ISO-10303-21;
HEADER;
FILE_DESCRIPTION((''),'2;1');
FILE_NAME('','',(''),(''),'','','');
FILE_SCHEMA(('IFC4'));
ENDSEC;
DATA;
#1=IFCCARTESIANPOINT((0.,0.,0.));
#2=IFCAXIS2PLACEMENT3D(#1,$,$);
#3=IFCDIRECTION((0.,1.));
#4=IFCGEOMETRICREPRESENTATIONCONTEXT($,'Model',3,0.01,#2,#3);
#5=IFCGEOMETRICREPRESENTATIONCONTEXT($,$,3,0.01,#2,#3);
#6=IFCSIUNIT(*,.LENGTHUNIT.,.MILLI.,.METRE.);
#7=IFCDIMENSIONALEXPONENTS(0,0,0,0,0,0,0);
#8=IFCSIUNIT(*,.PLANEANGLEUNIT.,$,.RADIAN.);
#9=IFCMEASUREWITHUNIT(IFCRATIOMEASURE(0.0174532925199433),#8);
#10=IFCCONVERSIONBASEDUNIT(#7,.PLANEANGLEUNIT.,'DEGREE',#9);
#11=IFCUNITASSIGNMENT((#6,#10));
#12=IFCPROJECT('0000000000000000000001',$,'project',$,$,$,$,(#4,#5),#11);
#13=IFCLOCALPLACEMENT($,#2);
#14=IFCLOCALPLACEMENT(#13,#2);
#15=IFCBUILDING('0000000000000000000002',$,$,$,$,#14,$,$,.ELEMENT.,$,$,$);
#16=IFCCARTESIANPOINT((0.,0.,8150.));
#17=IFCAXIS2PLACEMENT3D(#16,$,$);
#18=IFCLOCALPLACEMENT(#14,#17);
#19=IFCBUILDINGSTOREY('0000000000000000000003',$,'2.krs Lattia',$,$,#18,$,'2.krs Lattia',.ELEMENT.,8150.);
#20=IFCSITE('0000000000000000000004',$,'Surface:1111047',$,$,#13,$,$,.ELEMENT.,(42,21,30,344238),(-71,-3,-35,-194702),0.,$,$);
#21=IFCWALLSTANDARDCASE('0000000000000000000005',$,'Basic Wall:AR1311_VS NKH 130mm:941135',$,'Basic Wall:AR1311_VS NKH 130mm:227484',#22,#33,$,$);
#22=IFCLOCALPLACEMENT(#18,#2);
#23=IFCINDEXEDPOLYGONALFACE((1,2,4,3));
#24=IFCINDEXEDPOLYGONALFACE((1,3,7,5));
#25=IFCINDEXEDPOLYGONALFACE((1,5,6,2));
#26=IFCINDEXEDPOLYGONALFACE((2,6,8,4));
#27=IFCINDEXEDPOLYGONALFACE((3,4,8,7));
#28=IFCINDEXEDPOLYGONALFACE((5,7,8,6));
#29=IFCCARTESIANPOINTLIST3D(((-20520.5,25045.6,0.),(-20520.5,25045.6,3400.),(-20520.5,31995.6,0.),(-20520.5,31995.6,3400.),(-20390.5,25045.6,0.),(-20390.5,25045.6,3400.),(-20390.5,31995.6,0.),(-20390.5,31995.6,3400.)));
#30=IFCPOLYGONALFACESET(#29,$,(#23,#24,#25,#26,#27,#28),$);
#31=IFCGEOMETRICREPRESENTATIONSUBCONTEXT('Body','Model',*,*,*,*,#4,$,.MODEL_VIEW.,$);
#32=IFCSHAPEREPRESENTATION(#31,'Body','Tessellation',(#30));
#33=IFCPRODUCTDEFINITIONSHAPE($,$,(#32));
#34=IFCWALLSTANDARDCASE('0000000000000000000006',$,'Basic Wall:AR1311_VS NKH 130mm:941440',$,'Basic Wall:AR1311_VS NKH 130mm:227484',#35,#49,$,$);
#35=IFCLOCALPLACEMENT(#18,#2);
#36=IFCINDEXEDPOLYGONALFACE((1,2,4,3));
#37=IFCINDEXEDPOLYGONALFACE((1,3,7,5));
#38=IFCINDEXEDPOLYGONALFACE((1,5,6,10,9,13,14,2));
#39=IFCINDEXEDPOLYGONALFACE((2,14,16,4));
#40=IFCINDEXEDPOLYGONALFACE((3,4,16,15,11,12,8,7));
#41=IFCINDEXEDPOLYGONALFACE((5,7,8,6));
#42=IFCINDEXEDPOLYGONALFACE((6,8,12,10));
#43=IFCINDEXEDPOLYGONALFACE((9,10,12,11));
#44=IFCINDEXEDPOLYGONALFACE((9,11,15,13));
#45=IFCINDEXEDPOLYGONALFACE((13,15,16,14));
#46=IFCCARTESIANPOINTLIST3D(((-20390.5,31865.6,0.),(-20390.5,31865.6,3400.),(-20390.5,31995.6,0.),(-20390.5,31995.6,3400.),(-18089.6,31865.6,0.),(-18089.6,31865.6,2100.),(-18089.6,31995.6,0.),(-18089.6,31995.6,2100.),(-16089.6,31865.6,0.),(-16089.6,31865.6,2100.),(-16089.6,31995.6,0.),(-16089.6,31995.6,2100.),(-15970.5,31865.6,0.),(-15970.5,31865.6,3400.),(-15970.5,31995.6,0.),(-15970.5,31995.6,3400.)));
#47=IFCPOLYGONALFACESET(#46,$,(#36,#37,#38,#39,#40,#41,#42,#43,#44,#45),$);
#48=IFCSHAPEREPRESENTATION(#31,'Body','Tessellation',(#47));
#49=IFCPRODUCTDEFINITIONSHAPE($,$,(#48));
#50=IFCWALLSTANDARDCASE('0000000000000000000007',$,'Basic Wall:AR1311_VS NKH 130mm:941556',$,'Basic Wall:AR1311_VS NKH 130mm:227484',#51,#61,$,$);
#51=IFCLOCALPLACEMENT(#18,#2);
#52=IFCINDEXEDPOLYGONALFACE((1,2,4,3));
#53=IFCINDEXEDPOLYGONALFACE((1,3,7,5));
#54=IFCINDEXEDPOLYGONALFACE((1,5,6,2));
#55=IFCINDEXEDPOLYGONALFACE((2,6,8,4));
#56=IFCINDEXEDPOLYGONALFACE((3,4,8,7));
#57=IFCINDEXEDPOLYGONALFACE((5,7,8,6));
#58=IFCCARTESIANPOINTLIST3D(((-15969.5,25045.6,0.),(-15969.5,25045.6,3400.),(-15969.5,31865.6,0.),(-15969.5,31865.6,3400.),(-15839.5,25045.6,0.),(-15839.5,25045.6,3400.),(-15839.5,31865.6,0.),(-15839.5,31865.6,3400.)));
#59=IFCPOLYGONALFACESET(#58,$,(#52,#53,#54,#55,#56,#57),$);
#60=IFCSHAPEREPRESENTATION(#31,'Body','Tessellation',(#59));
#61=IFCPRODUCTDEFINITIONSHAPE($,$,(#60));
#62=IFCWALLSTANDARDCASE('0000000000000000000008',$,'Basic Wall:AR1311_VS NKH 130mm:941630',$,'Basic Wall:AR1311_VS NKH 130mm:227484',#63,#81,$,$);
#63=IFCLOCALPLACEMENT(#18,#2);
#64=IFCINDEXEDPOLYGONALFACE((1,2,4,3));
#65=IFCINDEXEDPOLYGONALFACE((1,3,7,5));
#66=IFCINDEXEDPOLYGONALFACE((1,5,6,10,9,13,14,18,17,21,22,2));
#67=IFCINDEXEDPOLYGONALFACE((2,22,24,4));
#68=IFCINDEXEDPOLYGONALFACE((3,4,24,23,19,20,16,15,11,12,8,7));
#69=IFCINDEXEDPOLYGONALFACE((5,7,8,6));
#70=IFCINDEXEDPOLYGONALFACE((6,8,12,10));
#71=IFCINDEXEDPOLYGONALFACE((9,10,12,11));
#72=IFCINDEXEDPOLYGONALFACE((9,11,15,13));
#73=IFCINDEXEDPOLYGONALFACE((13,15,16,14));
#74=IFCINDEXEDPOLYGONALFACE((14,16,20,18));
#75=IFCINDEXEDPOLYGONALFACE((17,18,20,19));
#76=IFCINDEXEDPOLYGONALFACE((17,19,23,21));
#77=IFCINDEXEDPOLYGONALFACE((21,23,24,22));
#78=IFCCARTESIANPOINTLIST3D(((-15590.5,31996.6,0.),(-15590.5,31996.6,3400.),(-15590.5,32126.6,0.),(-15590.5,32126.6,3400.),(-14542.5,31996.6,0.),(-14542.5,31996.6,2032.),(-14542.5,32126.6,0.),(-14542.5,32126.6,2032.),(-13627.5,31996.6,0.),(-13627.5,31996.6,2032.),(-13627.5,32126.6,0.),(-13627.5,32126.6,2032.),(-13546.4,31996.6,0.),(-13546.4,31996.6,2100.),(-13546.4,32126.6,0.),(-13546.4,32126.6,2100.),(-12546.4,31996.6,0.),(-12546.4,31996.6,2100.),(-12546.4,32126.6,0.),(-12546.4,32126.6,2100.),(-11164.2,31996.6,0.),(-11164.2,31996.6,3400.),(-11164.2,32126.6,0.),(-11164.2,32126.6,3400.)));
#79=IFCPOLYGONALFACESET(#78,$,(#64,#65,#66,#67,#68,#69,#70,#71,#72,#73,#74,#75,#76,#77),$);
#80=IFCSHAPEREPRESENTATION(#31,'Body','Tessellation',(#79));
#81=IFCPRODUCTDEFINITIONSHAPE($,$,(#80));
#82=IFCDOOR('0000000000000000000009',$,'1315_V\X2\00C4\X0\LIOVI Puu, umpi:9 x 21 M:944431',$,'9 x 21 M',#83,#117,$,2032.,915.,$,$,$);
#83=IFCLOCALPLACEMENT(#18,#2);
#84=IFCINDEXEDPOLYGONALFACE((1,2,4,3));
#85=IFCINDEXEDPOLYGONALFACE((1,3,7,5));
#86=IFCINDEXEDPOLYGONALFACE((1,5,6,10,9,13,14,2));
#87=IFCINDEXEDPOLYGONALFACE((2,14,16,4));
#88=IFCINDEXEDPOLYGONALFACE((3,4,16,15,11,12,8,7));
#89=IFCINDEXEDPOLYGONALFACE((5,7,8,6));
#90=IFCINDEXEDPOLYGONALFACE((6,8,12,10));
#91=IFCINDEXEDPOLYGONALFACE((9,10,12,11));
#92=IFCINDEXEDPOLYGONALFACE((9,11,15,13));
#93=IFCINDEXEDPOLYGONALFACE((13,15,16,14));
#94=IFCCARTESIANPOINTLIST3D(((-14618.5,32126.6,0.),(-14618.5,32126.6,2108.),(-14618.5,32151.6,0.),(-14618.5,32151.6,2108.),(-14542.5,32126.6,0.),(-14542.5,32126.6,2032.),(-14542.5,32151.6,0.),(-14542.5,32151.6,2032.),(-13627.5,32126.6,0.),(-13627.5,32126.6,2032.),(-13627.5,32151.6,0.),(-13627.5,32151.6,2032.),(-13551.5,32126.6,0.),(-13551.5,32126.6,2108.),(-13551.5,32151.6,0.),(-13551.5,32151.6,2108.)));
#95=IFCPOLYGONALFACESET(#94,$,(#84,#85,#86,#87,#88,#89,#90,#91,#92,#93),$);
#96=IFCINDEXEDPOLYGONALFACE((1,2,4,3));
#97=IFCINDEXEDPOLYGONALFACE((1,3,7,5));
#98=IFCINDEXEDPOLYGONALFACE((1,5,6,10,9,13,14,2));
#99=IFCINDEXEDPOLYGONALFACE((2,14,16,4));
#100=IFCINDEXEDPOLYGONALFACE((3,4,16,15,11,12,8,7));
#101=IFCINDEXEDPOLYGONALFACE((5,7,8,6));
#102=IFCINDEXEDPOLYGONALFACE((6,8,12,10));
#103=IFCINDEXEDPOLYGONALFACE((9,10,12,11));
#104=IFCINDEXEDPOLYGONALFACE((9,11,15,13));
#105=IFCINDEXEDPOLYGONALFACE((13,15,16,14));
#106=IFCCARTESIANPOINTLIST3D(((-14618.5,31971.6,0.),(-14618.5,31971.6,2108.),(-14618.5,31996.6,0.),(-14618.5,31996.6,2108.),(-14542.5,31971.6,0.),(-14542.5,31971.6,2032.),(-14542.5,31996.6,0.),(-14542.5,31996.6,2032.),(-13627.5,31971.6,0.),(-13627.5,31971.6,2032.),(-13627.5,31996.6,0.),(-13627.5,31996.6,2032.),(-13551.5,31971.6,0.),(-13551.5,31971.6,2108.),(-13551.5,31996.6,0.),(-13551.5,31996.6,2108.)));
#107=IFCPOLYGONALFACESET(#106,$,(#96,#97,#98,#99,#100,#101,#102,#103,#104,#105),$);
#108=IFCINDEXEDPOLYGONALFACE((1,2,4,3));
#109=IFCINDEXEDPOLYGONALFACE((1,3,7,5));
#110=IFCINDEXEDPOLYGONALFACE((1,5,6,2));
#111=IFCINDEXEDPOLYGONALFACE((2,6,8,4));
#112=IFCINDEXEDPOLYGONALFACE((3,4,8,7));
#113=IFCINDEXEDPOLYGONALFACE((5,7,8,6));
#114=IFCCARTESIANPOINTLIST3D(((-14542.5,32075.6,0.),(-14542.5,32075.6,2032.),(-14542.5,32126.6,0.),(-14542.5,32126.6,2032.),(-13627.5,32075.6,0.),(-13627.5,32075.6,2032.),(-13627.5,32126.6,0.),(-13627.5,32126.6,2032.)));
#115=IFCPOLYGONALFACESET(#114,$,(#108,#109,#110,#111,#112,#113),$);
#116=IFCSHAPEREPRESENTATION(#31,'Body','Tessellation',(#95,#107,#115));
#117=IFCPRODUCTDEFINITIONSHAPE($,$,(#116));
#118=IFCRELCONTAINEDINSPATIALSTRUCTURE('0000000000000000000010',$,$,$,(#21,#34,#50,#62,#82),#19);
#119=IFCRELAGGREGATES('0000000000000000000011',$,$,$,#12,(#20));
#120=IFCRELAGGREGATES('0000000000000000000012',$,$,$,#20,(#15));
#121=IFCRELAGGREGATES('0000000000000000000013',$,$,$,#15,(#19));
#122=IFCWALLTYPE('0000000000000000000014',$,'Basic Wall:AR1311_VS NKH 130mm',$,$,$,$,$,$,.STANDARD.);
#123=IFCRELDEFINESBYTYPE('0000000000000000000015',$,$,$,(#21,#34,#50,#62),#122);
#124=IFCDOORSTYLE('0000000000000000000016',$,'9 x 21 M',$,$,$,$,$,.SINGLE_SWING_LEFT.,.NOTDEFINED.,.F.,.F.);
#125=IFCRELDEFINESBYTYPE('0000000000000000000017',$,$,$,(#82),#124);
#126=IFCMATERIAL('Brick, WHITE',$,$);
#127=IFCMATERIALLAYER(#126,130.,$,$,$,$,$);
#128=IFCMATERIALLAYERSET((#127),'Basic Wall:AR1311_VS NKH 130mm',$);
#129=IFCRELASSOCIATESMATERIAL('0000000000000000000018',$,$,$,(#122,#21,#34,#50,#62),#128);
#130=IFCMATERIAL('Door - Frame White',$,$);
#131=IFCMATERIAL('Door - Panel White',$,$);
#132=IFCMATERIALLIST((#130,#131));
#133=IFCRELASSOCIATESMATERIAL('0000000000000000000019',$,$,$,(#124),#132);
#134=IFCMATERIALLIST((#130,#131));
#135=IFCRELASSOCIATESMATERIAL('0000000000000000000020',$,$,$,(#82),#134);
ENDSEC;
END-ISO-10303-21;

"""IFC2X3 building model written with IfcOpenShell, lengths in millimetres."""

from ifc_helpers import new_model, entity, si_unit, converted_unit, direction, frame, frame_2d, origin, place, context, subcontext, project, spatial, polyline, rectangle, outline, extrude, source, transform, mapped, material, material_list, layer, layer_set, layer_usage, type_object, type_shapes, element, fill, save


model = new_model("IFC2X3")

# Units and contexts
model_context = context("Model", 3, precision=0.01, world=origin(), true_north=direction((0.0, 1.0)))
context_of_model = context(None, 3, precision=0.01, world=origin(), true_north=direction((0.0, 1.0)))
body_context = subcontext(model_context, "Body", "Model", "MODEL_VIEW")
ifc_project = project(units=[si_unit("LENGTHUNIT", "METRE", prefix="MILLI"), converted_unit("PLANEANGLEUNIT", "DEGREE", entity("IfcRatioMeasure", 0.0174532925199433), si_unit("PLANEANGLEUNIT", "RADIAN"), dimensions=[0, 0, 0, 0, 0, 0, 0])], contexts=[model_context, context_of_model])

# Site, building, storey
site_placement = place(None, origin())
site = spatial("IfcSite", under=ifc_project, at=site_placement, Name="Surface:1111047", CompositionType="ELEMENT", RefLatitude=(42, 21, 30, 344238), RefLongitude=(-71, -3, -35, -194702), RefElevation=0.0)
building_placement = place(site_placement, origin())
building = spatial("IfcBuilding", under=site, at=building_placement, CompositionType="ELEMENT")
storey_placement = place(building_placement, frame((0.0, 0.0, 8150.0)))
storey = spatial("IfcBuildingStorey", under=building, at=storey_placement, Name="2.krs Lattia", LongName="2.krs Lattia", CompositionType="ELEMENT", Elevation=8150.0)

# Wall
ifc_material_1 = material(Name="Brick, WHITE")
ifc_layer = layer(ifc_material_1, 130.0)
ifc_layer_set = layer_set([ifc_layer], Name="Basic Wall:AR1311_VS NKH 130mm")
ifc_layer_usage_1 = layer_usage(ifc_layer_set, "AXIS2", "NEGATIVE", 65.0)
wall_type = type_object("IfcWallType", Name="Basic Wall:AR1311_VS NKH 130mm", PredefinedType="STANDARD", material=ifc_layer_set)
wall_1_placement = place(storey_placement, frame((-20455.5, 25045.6, 0.0), z_axis=(0.0, 0.0, 1.0), x_axis=(0.0, 1.0, 0.0)))
element("IfcWallStandardCase", 1, at=wall_1_placement, inside=storey, type_object=wall_type, material=ifc_layer_usage_1, Name="Basic Wall:AR1311_VS NKH 130mm:941135", ObjectType="Basic Wall:AR1311_VS NKH 130mm:227484", context=body_context, shape_type="SweptSolid", body=[
    extrude(rectangle(XDim=6950.0, YDim=130.0, at=frame_2d((3475.0, 0.0), x_axis=(-1.0, 0.0))), origin(), (0.0, 0.0, 1.0), 3400.0),
])

# Wall, opening
ifc_layer_usage_2 = layer_usage(ifc_layer_set, "AXIS2", "NEGATIVE", 65.0)
wall_2_placement = place(storey_placement, frame((-20390.5, 31930.6, 0.0)))
wall_2 = element("IfcWallStandardCase", 2, at=wall_2_placement, inside=storey, type_object=wall_type, material=ifc_layer_usage_2, Name="Basic Wall:AR1311_VS NKH 130mm:941440", ObjectType="Basic Wall:AR1311_VS NKH 130mm:227484", context=body_context, shape_type="SweptSolid", body=[
    extrude(rectangle(XDim=4420.0, YDim=130.0, at=frame_2d((2210.0, 0.0), x_axis=(-1.0, 0.0))), origin(), (0.0, 0.0, 1.0), 3400.0),
])
opening_1_placement = place(wall_2_placement, frame((2300.9, -65.0, 0.0)))
element("IfcOpeningElement", 3, at=opening_1_placement, cuts=wall_2, ObjectType="Opening", context=body_context, shape_type="SweptSolid", body=[
    extrude(rectangle(XDim=2100.0, YDim=2000.0, at=frame_2d((1050.0, 1000.0), x_axis=(1.0, 0.0))), frame((0.0, 0.0, 0.0), z_axis=(0.0, 1.0, 0.0), x_axis=(0.0, 0.0, 1.0)), (0.0, 0.0, 1.0), 130.0),
])

# Wall
ifc_layer_usage_3 = layer_usage(ifc_layer_set, "AXIS2", "NEGATIVE", 65.0)
wall_3_placement = place(storey_placement, frame((-15904.5, 31865.6, 0.0), z_axis=(0.0, 0.0, 1.0), x_axis=(0.0, -1.0, 0.0)))
element("IfcWallStandardCase", 4, at=wall_3_placement, inside=storey, type_object=wall_type, material=ifc_layer_usage_3, Name="Basic Wall:AR1311_VS NKH 130mm:941556", ObjectType="Basic Wall:AR1311_VS NKH 130mm:227484", context=body_context, shape_type="SweptSolid", body=[
    extrude(rectangle(XDim=6820.0, YDim=130.0, at=frame_2d((3410.0, 0.0), x_axis=(-1.0, 0.0))), origin(), (0.0, 0.0, 1.0), 3400.0),
])

# Wall, openings, door
ifc_layer_usage_4 = layer_usage(ifc_layer_set, "AXIS2", "NEGATIVE", 65.0)
wall_4_placement = place(storey_placement, frame((-15590.5, 32061.6, 0.0)))
wall_4 = element("IfcWallStandardCase", 5, at=wall_4_placement, inside=storey, type_object=wall_type, material=ifc_layer_usage_4, Name="Basic Wall:AR1311_VS NKH 130mm:941630", ObjectType="Basic Wall:AR1311_VS NKH 130mm:227484", context=body_context, shape_type="SweptSolid", body=[
    extrude(rectangle(XDim=4426.3, YDim=130.0, at=frame_2d((2213.2, 0.0), x_axis=(-1.0, 0.0))), origin(), (0.0, 0.0, 1.0), 3400.0),
])
opening_2_placement = place(wall_4_placement, origin())
element("IfcOpeningElement", 6, at=opening_2_placement, cuts=wall_4, ObjectType="Opening", context=body_context, shape_type="SweptSolid", body=[
    extrude(rectangle(XDim=2100.0, YDim=1000.0, at=frame_2d((0.0, 0.0), x_axis=(1.0, 0.0))), frame((2544.1, -65.0, 1050.0), z_axis=(0.0, 1.0, 0.0), x_axis=(0.0, 0.0, -1.0)), (0.0, 0.0, 1.0), 130.0),
])
opening_3_placement = place(wall_4_placement, frame((1048.0, -65.0, 0.0)))
opening_3 = element("IfcOpeningElement", 7, at=opening_3_placement, cuts=wall_4, ObjectType="Opening", context=body_context, shape_type="SweptSolid", body=[
    extrude(rectangle(XDim=915.0, YDim=2032.0, at=frame_2d((1016.0, 457.5), x_axis=(0.0, -1.0))), frame((0.0, 0.0, 0.0), z_axis=(0.0, 1.0, 0.0), x_axis=(0.0, 0.0, 1.0)), (0.0, 0.0, 1.0), 130.0),
])
ifc_material_2 = material(Name="Door - Frame White")
ifc_material_3 = material(Name="Door - Panel White")
ifc_material_list_1 = material_list([ifc_material_2, ifc_material_3])
ifc_material_list_2 = material_list([ifc_material_2, ifc_material_3])
door_style = type_object("IfcDoorStyle", Name="9 x 21 M", ConstructionType="NOTDEFINED", OperationType="SINGLE_SWING_LEFT", ParameterTakesPrecedence=False, Sizeable=False, material=ifc_material_list_2)
shared_shape = source(origin(), body_context, "Body", "SweptSolid", [
    extrude(outline(polyline([(-533.5, -1073.0), (533.5, -1073.0), (533.5, 1035.0), (457.5, 1035.0), (457.5, -997.0), (-457.5, -997.0), (-457.5, 1035.0), (-533.5, 1035.0), (-533.5, -1073.0)])), frame((457.5, 155.0, 1035.0), z_axis=(0.0, -1.0, 0.0), x_axis=(-1.0, 0.0, 0.0)), (0.0, 0.0, 1.0), 25.0),
    extrude(outline(polyline([(-1073.0, -533.5), (1035.0, -533.5), (1035.0, -457.5), (-997.0, -457.5), (-997.0, 457.5), (1035.0, 457.5), (1035.0, 533.5), (-1073.0, 533.5), (-1073.0, -533.5)])), frame((457.5, 0.0, 1035.0), z_axis=(0.0, -1.0, 0.0), x_axis=(0.0, 0.0, -1.0)), (0.0, 0.0, 1.0), 25.0),
    extrude(rectangle(XDim=915.0, YDim=51.0, at=frame_2d((0.0, 0.0), x_axis=(1.0, 0.0))), frame((457.5, 104.5, 0.0)), (0.0, 0.0, 1.0), 2032.0),
])
type_shapes(door_style, [shared_shape])
door_placement = place(opening_3_placement, origin())
door = element("IfcDoor", 8, at=door_placement, inside=storey, type_object=door_style, material=ifc_material_list_1, Name="1315_VÄLIOVI Puu, umpi:9 x 21 M:944431", ObjectType="9 x 21 M", OverallHeight=2032.0, OverallWidth=915.0, context=body_context, shape_type="MappedRepresentation", body=[
    mapped(shared_shape, transform((0.0, 0.0, 0.0), scale=1.0)),
])
fill(opening_3, door)

save(model, "model.ifc")
